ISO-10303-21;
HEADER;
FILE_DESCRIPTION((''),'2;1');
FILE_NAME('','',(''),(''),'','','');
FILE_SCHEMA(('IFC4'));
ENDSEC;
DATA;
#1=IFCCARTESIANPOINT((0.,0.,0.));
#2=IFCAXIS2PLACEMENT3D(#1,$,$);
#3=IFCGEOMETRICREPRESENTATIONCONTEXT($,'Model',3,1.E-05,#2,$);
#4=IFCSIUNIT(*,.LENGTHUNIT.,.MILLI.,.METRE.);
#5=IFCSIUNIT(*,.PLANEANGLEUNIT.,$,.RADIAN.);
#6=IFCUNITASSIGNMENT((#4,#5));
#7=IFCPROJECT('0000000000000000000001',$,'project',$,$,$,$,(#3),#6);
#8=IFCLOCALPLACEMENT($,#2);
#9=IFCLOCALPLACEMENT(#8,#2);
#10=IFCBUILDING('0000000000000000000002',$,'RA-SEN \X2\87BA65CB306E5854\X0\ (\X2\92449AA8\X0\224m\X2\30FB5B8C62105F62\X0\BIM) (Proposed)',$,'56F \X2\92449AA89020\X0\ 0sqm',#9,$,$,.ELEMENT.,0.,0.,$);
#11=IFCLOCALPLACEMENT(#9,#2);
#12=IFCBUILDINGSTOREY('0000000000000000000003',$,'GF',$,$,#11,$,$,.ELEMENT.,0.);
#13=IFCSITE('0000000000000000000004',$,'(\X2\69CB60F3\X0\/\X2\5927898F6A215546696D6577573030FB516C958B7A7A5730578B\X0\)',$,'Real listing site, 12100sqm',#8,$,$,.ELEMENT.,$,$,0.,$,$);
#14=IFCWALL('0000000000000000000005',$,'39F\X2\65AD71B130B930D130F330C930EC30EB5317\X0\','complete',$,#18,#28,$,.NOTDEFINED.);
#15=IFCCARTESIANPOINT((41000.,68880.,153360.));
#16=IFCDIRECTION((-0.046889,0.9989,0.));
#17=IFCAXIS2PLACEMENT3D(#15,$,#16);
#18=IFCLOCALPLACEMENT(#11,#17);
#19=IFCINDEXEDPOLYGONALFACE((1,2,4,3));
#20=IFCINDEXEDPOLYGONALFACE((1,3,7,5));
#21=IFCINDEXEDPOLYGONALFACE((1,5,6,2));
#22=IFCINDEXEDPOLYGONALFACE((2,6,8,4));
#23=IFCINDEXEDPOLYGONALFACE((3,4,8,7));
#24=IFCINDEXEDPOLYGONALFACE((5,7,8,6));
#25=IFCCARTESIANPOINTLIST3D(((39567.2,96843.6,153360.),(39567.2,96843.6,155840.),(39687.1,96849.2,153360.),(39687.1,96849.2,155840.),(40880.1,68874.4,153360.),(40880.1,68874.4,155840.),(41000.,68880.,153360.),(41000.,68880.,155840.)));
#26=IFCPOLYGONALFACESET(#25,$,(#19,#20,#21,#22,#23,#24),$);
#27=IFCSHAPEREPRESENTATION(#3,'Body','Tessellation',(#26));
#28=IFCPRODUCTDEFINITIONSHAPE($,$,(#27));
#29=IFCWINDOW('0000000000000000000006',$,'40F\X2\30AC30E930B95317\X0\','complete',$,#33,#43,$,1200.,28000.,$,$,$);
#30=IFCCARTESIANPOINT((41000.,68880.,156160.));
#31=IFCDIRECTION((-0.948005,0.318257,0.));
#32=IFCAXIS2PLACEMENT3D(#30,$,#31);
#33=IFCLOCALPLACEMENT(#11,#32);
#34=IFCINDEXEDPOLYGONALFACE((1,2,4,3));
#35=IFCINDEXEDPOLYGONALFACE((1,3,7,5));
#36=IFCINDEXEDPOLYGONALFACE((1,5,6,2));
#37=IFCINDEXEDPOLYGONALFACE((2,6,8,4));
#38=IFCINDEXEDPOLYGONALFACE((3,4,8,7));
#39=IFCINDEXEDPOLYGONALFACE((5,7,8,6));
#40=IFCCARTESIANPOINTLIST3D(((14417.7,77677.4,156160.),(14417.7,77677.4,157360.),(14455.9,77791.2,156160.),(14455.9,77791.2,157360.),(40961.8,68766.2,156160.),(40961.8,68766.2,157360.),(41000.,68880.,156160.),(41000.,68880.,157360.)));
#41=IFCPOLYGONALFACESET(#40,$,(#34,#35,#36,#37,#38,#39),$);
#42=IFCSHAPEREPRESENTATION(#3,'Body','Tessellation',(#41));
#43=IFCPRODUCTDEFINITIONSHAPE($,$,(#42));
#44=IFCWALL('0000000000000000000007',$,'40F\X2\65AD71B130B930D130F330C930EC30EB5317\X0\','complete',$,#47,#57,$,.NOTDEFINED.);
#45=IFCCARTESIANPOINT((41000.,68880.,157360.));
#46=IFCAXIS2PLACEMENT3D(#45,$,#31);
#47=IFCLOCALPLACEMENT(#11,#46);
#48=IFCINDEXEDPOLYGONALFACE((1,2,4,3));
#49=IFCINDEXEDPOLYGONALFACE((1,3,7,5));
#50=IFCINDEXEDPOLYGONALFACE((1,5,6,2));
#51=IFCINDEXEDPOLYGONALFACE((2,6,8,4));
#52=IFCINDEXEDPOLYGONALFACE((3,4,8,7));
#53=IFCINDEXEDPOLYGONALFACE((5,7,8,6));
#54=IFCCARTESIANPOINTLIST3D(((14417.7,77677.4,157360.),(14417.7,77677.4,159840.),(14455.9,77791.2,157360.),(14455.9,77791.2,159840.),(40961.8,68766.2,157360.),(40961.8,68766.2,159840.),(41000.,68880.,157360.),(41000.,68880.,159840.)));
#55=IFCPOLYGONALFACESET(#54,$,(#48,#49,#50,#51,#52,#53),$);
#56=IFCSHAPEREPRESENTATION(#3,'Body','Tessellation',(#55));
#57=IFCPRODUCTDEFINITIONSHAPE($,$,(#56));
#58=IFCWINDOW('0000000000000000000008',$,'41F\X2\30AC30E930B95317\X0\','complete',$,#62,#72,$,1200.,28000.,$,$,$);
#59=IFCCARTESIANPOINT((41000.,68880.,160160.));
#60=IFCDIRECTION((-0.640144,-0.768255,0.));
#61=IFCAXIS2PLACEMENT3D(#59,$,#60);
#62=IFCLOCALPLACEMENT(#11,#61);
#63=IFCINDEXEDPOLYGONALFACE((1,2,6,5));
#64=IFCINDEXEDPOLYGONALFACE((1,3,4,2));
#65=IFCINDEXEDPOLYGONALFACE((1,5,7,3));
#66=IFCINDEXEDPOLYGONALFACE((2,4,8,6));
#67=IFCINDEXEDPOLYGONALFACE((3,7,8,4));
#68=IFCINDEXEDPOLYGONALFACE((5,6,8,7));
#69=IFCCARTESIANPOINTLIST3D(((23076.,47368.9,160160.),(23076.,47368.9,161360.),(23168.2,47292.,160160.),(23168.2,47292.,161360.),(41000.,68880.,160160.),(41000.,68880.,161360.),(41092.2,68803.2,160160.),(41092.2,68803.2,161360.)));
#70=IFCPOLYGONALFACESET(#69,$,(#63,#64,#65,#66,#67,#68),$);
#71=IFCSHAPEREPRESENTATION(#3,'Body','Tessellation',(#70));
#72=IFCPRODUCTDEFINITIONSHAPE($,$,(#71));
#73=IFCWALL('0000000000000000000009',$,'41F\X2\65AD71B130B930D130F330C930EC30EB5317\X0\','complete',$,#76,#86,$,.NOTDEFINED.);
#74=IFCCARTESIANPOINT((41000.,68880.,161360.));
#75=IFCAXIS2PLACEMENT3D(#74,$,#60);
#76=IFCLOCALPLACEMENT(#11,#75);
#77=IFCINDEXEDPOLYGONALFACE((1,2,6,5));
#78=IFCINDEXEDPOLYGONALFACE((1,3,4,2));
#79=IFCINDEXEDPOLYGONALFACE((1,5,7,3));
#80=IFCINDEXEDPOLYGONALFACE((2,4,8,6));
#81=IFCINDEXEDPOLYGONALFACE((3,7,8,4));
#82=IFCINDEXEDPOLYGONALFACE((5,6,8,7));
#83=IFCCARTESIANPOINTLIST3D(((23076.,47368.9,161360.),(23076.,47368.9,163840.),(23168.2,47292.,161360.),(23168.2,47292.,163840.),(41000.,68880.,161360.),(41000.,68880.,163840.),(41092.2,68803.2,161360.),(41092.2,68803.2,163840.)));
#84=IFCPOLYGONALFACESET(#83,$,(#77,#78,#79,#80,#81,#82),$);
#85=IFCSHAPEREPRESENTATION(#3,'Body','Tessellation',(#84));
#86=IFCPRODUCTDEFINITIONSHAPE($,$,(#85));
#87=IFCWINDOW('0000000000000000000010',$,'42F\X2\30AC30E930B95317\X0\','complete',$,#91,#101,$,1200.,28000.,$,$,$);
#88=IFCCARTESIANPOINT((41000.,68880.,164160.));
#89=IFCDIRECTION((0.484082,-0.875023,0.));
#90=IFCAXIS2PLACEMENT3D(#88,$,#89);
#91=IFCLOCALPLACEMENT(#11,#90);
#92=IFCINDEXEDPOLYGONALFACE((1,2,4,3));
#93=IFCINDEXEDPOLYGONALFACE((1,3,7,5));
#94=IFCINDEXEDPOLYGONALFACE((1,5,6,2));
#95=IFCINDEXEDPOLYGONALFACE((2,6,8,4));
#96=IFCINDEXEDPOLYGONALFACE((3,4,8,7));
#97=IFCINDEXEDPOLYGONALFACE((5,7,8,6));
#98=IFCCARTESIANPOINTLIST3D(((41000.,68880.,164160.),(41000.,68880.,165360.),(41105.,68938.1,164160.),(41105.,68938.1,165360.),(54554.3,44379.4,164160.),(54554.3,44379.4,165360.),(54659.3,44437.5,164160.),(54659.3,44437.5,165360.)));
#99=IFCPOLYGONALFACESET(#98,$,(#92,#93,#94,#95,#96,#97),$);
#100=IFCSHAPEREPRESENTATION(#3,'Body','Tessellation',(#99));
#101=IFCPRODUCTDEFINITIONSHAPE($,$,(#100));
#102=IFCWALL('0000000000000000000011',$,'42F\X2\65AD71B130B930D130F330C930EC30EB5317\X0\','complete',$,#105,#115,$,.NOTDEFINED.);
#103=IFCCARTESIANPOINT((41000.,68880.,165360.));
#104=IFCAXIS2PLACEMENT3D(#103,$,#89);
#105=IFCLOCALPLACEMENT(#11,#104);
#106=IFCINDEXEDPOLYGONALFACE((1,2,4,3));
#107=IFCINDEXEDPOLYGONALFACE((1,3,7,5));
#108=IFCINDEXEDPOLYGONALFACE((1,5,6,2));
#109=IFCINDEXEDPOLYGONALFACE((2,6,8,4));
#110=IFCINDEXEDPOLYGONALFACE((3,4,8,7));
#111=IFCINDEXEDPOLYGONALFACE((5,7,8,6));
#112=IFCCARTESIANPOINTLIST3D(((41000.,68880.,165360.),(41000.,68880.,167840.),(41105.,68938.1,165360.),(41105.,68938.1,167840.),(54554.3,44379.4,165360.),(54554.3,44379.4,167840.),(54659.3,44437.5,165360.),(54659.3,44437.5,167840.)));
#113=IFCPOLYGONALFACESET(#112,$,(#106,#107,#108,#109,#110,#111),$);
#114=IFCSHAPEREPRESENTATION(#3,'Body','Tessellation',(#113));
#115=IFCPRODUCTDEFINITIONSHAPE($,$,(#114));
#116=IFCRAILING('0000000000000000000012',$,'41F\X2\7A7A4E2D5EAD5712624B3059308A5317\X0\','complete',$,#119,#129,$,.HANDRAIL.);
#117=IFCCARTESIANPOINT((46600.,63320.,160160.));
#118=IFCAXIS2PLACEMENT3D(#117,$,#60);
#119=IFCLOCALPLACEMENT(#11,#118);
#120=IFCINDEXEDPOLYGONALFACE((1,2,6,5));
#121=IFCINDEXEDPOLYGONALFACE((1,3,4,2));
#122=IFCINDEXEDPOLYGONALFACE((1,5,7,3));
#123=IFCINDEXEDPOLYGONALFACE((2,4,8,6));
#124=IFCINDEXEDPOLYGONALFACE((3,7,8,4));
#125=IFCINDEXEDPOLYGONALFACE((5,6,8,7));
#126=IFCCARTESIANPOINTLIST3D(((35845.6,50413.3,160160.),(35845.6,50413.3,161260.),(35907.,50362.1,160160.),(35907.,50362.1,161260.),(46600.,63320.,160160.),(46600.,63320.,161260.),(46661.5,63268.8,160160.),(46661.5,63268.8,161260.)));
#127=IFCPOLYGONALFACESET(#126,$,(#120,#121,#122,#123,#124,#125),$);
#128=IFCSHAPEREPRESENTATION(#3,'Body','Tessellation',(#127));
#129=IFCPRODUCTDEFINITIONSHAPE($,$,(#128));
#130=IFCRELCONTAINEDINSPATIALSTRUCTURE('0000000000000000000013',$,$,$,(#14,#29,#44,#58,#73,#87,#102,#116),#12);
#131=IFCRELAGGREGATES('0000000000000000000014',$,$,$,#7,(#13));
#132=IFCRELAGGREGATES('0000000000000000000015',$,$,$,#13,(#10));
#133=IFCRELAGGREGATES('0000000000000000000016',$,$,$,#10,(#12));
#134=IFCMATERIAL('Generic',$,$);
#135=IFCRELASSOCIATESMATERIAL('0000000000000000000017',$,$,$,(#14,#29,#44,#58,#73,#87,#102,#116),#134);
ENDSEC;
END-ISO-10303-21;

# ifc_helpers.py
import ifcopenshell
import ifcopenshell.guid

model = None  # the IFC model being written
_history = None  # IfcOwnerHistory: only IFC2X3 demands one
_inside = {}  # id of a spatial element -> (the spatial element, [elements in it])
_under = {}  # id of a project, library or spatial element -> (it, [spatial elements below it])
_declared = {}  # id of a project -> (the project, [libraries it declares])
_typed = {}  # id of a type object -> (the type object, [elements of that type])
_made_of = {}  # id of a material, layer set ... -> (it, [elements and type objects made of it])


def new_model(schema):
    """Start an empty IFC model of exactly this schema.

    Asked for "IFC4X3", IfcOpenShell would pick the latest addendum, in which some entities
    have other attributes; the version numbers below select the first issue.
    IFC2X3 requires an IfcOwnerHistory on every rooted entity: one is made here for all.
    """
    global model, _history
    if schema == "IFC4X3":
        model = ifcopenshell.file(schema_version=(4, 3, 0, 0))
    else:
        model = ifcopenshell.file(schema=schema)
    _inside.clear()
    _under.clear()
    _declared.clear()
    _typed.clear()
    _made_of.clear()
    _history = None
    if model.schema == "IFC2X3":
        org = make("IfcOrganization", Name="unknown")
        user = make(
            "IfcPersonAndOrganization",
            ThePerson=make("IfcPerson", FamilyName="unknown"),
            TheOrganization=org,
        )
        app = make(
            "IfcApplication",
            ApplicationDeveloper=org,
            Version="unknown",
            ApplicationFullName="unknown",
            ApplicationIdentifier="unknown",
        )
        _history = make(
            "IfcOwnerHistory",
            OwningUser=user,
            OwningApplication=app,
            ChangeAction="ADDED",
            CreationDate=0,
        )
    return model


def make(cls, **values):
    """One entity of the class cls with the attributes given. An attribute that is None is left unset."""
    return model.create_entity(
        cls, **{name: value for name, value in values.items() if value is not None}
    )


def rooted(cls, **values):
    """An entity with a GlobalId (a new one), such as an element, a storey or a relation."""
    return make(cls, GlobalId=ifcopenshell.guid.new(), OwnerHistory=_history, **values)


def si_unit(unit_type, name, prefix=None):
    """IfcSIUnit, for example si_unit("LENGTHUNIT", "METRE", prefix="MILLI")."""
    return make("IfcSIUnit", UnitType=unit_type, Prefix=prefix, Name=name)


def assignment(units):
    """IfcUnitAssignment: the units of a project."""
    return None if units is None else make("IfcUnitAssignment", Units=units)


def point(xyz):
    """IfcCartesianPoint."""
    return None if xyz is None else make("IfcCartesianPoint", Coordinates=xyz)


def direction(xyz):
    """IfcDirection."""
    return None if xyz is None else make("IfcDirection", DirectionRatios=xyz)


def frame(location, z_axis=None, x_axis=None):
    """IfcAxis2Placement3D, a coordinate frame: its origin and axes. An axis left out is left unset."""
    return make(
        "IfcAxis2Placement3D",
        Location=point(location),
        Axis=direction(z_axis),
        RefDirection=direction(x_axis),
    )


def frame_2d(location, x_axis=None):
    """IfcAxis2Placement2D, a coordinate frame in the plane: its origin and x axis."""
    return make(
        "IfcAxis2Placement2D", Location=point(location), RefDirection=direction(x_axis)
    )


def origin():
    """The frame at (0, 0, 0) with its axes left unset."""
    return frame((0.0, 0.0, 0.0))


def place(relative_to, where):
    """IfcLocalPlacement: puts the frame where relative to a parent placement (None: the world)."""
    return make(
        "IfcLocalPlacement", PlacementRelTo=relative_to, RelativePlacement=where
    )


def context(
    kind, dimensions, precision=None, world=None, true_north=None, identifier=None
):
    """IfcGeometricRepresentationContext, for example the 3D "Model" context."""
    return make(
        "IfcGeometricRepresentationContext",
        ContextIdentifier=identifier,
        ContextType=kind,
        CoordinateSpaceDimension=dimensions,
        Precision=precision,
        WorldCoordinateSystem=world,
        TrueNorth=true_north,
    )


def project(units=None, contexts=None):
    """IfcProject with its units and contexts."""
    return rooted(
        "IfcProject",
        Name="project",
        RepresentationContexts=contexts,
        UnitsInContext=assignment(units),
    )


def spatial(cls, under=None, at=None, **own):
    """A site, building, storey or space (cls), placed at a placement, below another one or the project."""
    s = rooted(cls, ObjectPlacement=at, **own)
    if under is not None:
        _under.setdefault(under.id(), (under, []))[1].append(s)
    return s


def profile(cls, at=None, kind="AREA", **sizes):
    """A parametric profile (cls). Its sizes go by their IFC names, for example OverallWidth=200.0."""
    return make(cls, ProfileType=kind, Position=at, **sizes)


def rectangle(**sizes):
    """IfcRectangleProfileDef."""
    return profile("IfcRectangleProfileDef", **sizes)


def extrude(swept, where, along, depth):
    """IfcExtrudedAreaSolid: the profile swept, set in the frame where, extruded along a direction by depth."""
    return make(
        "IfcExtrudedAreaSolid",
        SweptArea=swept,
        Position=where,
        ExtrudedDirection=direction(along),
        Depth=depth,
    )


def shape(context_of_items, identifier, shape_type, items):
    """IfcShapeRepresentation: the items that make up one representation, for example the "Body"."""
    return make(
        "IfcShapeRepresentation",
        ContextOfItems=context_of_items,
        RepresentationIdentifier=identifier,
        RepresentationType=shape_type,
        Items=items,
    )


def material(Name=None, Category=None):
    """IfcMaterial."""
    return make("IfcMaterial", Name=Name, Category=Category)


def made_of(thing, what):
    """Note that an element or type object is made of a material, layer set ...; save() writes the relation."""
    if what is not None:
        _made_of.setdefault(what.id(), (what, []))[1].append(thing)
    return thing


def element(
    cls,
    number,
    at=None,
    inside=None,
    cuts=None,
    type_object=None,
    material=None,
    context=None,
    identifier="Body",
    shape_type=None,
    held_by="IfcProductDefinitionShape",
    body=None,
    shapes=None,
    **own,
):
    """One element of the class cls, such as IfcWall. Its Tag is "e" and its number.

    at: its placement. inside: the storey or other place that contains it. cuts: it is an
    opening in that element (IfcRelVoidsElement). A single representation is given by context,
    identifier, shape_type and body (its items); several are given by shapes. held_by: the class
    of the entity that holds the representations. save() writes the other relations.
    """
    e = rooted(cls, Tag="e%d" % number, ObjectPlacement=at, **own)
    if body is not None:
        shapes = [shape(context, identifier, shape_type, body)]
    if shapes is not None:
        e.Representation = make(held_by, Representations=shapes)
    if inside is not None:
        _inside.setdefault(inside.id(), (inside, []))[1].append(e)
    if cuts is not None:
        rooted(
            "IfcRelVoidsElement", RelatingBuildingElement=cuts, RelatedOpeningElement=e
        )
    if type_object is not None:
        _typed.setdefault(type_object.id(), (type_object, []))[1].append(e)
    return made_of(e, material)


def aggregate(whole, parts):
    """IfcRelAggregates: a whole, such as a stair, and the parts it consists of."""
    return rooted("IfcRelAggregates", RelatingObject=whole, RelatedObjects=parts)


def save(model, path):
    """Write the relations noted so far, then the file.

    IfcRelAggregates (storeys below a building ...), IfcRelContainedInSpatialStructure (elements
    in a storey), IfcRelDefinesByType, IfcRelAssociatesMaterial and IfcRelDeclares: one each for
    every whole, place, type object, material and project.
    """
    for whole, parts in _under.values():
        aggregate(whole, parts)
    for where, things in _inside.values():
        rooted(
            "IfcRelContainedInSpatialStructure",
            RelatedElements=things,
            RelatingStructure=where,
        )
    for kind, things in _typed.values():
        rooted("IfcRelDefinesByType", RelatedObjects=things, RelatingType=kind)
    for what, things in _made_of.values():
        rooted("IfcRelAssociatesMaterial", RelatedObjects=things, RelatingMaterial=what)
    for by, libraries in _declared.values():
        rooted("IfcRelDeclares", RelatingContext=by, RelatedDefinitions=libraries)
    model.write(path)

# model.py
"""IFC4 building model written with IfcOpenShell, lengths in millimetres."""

from ifc_helpers import new_model, si_unit, frame, frame_2d, origin, place, context, project, spatial, rectangle, extrude, material, element, save


model = new_model("IFC4")

# Units and contexts
model_context = context("Model", 3, precision=1e-05, world=origin())
ifc_project = project(units=[si_unit("LENGTHUNIT", "METRE", prefix="MILLI"), si_unit("PLANEANGLEUNIT", "RADIAN")], contexts=[model_context])

# Site, building, storey
site_placement = place(None, origin())
site = spatial("IfcSite", under=ifc_project, at=site_placement, Name="(構想/大規模商業敷地・公開空地型)", ObjectType="Real listing site, 12100sqm", CompositionType="ELEMENT", RefElevation=0.0)
building_placement = place(site_placement, origin())
building = spatial("IfcBuilding", under=site, at=building_placement, Name="RA-SEN 螺旋の塔 (鉄骨224m・完成形BIM) (Proposed)", ObjectType="56F 鉄骨造 0sqm", CompositionType="ELEMENT", ElevationOfRefHeight=0.0, ElevationOfTerrain=0.0)
storey_placement = place(building_placement, origin())
storey = spatial("IfcBuildingStorey", under=building, at=storey_placement, Name="GF", CompositionType="ELEMENT", Elevation=0.0)

# Shared definitions
ifc_material = material(Name="Generic")

# Wall
wall_1_placement = place(storey_placement, frame((41000.0, 68880.0, 153360.0), x_axis=(-0.046889, 0.9989, 0.0)))
element("IfcWall", 1, at=wall_1_placement, inside=storey, material=ifc_material, Name="39F断熱スパンドレル北", Description="complete", PredefinedType="NOTDEFINED", context=model_context, shape_type="SweptSolid", body=[
    extrude(rectangle(XDim=28000.0, YDim=120.0, at=frame_2d((14000.0, 60.0))), frame((41000.0, 68880.0, 153360.0), x_axis=(-0.046889, 0.9989, 0.0)), (0.0, 0.0, 1.0), 2480.0),
])

# Window
window_1_placement = place(storey_placement, frame((41000.0, 68880.0, 156160.0), x_axis=(-0.948005, 0.318257, 0.0)))
element("IfcWindow", 2, at=window_1_placement, inside=storey, material=ifc_material, Name="40Fガラス北", Description="complete", OverallHeight=1200.0, OverallWidth=28000.0, context=model_context, shape_type="SweptSolid", body=[
    extrude(rectangle(XDim=28000.0, YDim=120.0, at=frame_2d((14000.0, 60.0))), frame((41000.0, 68880.0, 156160.0), x_axis=(-0.948005, 0.318257, 0.0)), (0.0, 0.0, 1.0), 1200.0),
])

# Wall
wall_2_placement = place(storey_placement, frame((41000.0, 68880.0, 157360.0), x_axis=(-0.948005, 0.318257, 0.0)))
element("IfcWall", 3, at=wall_2_placement, inside=storey, material=ifc_material, Name="40F断熱スパンドレル北", Description="complete", PredefinedType="NOTDEFINED", context=model_context, shape_type="SweptSolid", body=[
    extrude(rectangle(XDim=28000.0, YDim=120.0, at=frame_2d((14000.0, 60.0))), frame((41000.0, 68880.0, 157360.0), x_axis=(-0.948005, 0.318257, 0.0)), (0.0, 0.0, 1.0), 2480.0),
])

# Window
window_2_placement = place(storey_placement, frame((41000.0, 68880.0, 160160.0), x_axis=(-0.640144, -0.768255, 0.0)))
element("IfcWindow", 4, at=window_2_placement, inside=storey, material=ifc_material, Name="41Fガラス北", Description="complete", OverallHeight=1200.0, OverallWidth=28000.0, context=model_context, shape_type="SweptSolid", body=[
    extrude(rectangle(XDim=28000.0, YDim=120.0, at=frame_2d((14000.0, 60.0))), frame((41000.0, 68880.0, 160160.0), x_axis=(-0.640144, -0.768255, 0.0)), (0.0, 0.0, 1.0), 1200.0),
])

# Wall
wall_3_placement = place(storey_placement, frame((41000.0, 68880.0, 161360.0), x_axis=(-0.640144, -0.768255, 0.0)))
element("IfcWall", 5, at=wall_3_placement, inside=storey, material=ifc_material, Name="41F断熱スパンドレル北", Description="complete", PredefinedType="NOTDEFINED", context=model_context, shape_type="SweptSolid", body=[
    extrude(rectangle(XDim=28000.0, YDim=120.0, at=frame_2d((14000.0, 60.0))), frame((41000.0, 68880.0, 161360.0), x_axis=(-0.640144, -0.768255, 0.0)), (0.0, 0.0, 1.0), 2480.0),
])

# Window
window_3_placement = place(storey_placement, frame((41000.0, 68880.0, 164160.0), x_axis=(0.484082, -0.875023, 0.0)))
element("IfcWindow", 6, at=window_3_placement, inside=storey, material=ifc_material, Name="42Fガラス北", Description="complete", OverallHeight=1200.0, OverallWidth=28000.0, context=model_context, shape_type="SweptSolid", body=[
    extrude(rectangle(XDim=28000.0, YDim=120.0, at=frame_2d((14000.0, 60.0))), frame((41000.0, 68880.0, 164160.0), x_axis=(0.484082, -0.875023, 0.0)), (0.0, 0.0, 1.0), 1200.0),
])

# Wall
wall_4_placement = place(storey_placement, frame((41000.0, 68880.0, 165360.0), x_axis=(0.484082, -0.875023, 0.0)))
element("IfcWall", 7, at=wall_4_placement, inside=storey, material=ifc_material, Name="42F断熱スパンドレル北", Description="complete", PredefinedType="NOTDEFINED", context=model_context, shape_type="SweptSolid", body=[
    extrude(rectangle(XDim=28000.0, YDim=120.0, at=frame_2d((14000.0, 60.0))), frame((41000.0, 68880.0, 165360.0), x_axis=(0.484082, -0.875023, 0.0)), (0.0, 0.0, 1.0), 2480.0),
])

# Railing
railing_placement = place(storey_placement, frame((46600.0, 63320.0, 160160.0), x_axis=(-0.640144, -0.768255, 0.0)))
element("IfcRailing", 8, at=railing_placement, inside=storey, material=ifc_material, Name="41F空中庭園手すり北", Description="complete", PredefinedType="HANDRAIL", context=model_context, shape_type="SweptSolid", body=[
    extrude(rectangle(XDim=16800.0, YDim=80.0, at=frame_2d((8400.0, 40.0))), frame((46600.0, 63320.0, 160160.0), x_axis=(-0.640144, -0.768255, 0.0)), (0.0, 0.0, 1.0), 1100.0),
])

save(model, "model.ifc")
